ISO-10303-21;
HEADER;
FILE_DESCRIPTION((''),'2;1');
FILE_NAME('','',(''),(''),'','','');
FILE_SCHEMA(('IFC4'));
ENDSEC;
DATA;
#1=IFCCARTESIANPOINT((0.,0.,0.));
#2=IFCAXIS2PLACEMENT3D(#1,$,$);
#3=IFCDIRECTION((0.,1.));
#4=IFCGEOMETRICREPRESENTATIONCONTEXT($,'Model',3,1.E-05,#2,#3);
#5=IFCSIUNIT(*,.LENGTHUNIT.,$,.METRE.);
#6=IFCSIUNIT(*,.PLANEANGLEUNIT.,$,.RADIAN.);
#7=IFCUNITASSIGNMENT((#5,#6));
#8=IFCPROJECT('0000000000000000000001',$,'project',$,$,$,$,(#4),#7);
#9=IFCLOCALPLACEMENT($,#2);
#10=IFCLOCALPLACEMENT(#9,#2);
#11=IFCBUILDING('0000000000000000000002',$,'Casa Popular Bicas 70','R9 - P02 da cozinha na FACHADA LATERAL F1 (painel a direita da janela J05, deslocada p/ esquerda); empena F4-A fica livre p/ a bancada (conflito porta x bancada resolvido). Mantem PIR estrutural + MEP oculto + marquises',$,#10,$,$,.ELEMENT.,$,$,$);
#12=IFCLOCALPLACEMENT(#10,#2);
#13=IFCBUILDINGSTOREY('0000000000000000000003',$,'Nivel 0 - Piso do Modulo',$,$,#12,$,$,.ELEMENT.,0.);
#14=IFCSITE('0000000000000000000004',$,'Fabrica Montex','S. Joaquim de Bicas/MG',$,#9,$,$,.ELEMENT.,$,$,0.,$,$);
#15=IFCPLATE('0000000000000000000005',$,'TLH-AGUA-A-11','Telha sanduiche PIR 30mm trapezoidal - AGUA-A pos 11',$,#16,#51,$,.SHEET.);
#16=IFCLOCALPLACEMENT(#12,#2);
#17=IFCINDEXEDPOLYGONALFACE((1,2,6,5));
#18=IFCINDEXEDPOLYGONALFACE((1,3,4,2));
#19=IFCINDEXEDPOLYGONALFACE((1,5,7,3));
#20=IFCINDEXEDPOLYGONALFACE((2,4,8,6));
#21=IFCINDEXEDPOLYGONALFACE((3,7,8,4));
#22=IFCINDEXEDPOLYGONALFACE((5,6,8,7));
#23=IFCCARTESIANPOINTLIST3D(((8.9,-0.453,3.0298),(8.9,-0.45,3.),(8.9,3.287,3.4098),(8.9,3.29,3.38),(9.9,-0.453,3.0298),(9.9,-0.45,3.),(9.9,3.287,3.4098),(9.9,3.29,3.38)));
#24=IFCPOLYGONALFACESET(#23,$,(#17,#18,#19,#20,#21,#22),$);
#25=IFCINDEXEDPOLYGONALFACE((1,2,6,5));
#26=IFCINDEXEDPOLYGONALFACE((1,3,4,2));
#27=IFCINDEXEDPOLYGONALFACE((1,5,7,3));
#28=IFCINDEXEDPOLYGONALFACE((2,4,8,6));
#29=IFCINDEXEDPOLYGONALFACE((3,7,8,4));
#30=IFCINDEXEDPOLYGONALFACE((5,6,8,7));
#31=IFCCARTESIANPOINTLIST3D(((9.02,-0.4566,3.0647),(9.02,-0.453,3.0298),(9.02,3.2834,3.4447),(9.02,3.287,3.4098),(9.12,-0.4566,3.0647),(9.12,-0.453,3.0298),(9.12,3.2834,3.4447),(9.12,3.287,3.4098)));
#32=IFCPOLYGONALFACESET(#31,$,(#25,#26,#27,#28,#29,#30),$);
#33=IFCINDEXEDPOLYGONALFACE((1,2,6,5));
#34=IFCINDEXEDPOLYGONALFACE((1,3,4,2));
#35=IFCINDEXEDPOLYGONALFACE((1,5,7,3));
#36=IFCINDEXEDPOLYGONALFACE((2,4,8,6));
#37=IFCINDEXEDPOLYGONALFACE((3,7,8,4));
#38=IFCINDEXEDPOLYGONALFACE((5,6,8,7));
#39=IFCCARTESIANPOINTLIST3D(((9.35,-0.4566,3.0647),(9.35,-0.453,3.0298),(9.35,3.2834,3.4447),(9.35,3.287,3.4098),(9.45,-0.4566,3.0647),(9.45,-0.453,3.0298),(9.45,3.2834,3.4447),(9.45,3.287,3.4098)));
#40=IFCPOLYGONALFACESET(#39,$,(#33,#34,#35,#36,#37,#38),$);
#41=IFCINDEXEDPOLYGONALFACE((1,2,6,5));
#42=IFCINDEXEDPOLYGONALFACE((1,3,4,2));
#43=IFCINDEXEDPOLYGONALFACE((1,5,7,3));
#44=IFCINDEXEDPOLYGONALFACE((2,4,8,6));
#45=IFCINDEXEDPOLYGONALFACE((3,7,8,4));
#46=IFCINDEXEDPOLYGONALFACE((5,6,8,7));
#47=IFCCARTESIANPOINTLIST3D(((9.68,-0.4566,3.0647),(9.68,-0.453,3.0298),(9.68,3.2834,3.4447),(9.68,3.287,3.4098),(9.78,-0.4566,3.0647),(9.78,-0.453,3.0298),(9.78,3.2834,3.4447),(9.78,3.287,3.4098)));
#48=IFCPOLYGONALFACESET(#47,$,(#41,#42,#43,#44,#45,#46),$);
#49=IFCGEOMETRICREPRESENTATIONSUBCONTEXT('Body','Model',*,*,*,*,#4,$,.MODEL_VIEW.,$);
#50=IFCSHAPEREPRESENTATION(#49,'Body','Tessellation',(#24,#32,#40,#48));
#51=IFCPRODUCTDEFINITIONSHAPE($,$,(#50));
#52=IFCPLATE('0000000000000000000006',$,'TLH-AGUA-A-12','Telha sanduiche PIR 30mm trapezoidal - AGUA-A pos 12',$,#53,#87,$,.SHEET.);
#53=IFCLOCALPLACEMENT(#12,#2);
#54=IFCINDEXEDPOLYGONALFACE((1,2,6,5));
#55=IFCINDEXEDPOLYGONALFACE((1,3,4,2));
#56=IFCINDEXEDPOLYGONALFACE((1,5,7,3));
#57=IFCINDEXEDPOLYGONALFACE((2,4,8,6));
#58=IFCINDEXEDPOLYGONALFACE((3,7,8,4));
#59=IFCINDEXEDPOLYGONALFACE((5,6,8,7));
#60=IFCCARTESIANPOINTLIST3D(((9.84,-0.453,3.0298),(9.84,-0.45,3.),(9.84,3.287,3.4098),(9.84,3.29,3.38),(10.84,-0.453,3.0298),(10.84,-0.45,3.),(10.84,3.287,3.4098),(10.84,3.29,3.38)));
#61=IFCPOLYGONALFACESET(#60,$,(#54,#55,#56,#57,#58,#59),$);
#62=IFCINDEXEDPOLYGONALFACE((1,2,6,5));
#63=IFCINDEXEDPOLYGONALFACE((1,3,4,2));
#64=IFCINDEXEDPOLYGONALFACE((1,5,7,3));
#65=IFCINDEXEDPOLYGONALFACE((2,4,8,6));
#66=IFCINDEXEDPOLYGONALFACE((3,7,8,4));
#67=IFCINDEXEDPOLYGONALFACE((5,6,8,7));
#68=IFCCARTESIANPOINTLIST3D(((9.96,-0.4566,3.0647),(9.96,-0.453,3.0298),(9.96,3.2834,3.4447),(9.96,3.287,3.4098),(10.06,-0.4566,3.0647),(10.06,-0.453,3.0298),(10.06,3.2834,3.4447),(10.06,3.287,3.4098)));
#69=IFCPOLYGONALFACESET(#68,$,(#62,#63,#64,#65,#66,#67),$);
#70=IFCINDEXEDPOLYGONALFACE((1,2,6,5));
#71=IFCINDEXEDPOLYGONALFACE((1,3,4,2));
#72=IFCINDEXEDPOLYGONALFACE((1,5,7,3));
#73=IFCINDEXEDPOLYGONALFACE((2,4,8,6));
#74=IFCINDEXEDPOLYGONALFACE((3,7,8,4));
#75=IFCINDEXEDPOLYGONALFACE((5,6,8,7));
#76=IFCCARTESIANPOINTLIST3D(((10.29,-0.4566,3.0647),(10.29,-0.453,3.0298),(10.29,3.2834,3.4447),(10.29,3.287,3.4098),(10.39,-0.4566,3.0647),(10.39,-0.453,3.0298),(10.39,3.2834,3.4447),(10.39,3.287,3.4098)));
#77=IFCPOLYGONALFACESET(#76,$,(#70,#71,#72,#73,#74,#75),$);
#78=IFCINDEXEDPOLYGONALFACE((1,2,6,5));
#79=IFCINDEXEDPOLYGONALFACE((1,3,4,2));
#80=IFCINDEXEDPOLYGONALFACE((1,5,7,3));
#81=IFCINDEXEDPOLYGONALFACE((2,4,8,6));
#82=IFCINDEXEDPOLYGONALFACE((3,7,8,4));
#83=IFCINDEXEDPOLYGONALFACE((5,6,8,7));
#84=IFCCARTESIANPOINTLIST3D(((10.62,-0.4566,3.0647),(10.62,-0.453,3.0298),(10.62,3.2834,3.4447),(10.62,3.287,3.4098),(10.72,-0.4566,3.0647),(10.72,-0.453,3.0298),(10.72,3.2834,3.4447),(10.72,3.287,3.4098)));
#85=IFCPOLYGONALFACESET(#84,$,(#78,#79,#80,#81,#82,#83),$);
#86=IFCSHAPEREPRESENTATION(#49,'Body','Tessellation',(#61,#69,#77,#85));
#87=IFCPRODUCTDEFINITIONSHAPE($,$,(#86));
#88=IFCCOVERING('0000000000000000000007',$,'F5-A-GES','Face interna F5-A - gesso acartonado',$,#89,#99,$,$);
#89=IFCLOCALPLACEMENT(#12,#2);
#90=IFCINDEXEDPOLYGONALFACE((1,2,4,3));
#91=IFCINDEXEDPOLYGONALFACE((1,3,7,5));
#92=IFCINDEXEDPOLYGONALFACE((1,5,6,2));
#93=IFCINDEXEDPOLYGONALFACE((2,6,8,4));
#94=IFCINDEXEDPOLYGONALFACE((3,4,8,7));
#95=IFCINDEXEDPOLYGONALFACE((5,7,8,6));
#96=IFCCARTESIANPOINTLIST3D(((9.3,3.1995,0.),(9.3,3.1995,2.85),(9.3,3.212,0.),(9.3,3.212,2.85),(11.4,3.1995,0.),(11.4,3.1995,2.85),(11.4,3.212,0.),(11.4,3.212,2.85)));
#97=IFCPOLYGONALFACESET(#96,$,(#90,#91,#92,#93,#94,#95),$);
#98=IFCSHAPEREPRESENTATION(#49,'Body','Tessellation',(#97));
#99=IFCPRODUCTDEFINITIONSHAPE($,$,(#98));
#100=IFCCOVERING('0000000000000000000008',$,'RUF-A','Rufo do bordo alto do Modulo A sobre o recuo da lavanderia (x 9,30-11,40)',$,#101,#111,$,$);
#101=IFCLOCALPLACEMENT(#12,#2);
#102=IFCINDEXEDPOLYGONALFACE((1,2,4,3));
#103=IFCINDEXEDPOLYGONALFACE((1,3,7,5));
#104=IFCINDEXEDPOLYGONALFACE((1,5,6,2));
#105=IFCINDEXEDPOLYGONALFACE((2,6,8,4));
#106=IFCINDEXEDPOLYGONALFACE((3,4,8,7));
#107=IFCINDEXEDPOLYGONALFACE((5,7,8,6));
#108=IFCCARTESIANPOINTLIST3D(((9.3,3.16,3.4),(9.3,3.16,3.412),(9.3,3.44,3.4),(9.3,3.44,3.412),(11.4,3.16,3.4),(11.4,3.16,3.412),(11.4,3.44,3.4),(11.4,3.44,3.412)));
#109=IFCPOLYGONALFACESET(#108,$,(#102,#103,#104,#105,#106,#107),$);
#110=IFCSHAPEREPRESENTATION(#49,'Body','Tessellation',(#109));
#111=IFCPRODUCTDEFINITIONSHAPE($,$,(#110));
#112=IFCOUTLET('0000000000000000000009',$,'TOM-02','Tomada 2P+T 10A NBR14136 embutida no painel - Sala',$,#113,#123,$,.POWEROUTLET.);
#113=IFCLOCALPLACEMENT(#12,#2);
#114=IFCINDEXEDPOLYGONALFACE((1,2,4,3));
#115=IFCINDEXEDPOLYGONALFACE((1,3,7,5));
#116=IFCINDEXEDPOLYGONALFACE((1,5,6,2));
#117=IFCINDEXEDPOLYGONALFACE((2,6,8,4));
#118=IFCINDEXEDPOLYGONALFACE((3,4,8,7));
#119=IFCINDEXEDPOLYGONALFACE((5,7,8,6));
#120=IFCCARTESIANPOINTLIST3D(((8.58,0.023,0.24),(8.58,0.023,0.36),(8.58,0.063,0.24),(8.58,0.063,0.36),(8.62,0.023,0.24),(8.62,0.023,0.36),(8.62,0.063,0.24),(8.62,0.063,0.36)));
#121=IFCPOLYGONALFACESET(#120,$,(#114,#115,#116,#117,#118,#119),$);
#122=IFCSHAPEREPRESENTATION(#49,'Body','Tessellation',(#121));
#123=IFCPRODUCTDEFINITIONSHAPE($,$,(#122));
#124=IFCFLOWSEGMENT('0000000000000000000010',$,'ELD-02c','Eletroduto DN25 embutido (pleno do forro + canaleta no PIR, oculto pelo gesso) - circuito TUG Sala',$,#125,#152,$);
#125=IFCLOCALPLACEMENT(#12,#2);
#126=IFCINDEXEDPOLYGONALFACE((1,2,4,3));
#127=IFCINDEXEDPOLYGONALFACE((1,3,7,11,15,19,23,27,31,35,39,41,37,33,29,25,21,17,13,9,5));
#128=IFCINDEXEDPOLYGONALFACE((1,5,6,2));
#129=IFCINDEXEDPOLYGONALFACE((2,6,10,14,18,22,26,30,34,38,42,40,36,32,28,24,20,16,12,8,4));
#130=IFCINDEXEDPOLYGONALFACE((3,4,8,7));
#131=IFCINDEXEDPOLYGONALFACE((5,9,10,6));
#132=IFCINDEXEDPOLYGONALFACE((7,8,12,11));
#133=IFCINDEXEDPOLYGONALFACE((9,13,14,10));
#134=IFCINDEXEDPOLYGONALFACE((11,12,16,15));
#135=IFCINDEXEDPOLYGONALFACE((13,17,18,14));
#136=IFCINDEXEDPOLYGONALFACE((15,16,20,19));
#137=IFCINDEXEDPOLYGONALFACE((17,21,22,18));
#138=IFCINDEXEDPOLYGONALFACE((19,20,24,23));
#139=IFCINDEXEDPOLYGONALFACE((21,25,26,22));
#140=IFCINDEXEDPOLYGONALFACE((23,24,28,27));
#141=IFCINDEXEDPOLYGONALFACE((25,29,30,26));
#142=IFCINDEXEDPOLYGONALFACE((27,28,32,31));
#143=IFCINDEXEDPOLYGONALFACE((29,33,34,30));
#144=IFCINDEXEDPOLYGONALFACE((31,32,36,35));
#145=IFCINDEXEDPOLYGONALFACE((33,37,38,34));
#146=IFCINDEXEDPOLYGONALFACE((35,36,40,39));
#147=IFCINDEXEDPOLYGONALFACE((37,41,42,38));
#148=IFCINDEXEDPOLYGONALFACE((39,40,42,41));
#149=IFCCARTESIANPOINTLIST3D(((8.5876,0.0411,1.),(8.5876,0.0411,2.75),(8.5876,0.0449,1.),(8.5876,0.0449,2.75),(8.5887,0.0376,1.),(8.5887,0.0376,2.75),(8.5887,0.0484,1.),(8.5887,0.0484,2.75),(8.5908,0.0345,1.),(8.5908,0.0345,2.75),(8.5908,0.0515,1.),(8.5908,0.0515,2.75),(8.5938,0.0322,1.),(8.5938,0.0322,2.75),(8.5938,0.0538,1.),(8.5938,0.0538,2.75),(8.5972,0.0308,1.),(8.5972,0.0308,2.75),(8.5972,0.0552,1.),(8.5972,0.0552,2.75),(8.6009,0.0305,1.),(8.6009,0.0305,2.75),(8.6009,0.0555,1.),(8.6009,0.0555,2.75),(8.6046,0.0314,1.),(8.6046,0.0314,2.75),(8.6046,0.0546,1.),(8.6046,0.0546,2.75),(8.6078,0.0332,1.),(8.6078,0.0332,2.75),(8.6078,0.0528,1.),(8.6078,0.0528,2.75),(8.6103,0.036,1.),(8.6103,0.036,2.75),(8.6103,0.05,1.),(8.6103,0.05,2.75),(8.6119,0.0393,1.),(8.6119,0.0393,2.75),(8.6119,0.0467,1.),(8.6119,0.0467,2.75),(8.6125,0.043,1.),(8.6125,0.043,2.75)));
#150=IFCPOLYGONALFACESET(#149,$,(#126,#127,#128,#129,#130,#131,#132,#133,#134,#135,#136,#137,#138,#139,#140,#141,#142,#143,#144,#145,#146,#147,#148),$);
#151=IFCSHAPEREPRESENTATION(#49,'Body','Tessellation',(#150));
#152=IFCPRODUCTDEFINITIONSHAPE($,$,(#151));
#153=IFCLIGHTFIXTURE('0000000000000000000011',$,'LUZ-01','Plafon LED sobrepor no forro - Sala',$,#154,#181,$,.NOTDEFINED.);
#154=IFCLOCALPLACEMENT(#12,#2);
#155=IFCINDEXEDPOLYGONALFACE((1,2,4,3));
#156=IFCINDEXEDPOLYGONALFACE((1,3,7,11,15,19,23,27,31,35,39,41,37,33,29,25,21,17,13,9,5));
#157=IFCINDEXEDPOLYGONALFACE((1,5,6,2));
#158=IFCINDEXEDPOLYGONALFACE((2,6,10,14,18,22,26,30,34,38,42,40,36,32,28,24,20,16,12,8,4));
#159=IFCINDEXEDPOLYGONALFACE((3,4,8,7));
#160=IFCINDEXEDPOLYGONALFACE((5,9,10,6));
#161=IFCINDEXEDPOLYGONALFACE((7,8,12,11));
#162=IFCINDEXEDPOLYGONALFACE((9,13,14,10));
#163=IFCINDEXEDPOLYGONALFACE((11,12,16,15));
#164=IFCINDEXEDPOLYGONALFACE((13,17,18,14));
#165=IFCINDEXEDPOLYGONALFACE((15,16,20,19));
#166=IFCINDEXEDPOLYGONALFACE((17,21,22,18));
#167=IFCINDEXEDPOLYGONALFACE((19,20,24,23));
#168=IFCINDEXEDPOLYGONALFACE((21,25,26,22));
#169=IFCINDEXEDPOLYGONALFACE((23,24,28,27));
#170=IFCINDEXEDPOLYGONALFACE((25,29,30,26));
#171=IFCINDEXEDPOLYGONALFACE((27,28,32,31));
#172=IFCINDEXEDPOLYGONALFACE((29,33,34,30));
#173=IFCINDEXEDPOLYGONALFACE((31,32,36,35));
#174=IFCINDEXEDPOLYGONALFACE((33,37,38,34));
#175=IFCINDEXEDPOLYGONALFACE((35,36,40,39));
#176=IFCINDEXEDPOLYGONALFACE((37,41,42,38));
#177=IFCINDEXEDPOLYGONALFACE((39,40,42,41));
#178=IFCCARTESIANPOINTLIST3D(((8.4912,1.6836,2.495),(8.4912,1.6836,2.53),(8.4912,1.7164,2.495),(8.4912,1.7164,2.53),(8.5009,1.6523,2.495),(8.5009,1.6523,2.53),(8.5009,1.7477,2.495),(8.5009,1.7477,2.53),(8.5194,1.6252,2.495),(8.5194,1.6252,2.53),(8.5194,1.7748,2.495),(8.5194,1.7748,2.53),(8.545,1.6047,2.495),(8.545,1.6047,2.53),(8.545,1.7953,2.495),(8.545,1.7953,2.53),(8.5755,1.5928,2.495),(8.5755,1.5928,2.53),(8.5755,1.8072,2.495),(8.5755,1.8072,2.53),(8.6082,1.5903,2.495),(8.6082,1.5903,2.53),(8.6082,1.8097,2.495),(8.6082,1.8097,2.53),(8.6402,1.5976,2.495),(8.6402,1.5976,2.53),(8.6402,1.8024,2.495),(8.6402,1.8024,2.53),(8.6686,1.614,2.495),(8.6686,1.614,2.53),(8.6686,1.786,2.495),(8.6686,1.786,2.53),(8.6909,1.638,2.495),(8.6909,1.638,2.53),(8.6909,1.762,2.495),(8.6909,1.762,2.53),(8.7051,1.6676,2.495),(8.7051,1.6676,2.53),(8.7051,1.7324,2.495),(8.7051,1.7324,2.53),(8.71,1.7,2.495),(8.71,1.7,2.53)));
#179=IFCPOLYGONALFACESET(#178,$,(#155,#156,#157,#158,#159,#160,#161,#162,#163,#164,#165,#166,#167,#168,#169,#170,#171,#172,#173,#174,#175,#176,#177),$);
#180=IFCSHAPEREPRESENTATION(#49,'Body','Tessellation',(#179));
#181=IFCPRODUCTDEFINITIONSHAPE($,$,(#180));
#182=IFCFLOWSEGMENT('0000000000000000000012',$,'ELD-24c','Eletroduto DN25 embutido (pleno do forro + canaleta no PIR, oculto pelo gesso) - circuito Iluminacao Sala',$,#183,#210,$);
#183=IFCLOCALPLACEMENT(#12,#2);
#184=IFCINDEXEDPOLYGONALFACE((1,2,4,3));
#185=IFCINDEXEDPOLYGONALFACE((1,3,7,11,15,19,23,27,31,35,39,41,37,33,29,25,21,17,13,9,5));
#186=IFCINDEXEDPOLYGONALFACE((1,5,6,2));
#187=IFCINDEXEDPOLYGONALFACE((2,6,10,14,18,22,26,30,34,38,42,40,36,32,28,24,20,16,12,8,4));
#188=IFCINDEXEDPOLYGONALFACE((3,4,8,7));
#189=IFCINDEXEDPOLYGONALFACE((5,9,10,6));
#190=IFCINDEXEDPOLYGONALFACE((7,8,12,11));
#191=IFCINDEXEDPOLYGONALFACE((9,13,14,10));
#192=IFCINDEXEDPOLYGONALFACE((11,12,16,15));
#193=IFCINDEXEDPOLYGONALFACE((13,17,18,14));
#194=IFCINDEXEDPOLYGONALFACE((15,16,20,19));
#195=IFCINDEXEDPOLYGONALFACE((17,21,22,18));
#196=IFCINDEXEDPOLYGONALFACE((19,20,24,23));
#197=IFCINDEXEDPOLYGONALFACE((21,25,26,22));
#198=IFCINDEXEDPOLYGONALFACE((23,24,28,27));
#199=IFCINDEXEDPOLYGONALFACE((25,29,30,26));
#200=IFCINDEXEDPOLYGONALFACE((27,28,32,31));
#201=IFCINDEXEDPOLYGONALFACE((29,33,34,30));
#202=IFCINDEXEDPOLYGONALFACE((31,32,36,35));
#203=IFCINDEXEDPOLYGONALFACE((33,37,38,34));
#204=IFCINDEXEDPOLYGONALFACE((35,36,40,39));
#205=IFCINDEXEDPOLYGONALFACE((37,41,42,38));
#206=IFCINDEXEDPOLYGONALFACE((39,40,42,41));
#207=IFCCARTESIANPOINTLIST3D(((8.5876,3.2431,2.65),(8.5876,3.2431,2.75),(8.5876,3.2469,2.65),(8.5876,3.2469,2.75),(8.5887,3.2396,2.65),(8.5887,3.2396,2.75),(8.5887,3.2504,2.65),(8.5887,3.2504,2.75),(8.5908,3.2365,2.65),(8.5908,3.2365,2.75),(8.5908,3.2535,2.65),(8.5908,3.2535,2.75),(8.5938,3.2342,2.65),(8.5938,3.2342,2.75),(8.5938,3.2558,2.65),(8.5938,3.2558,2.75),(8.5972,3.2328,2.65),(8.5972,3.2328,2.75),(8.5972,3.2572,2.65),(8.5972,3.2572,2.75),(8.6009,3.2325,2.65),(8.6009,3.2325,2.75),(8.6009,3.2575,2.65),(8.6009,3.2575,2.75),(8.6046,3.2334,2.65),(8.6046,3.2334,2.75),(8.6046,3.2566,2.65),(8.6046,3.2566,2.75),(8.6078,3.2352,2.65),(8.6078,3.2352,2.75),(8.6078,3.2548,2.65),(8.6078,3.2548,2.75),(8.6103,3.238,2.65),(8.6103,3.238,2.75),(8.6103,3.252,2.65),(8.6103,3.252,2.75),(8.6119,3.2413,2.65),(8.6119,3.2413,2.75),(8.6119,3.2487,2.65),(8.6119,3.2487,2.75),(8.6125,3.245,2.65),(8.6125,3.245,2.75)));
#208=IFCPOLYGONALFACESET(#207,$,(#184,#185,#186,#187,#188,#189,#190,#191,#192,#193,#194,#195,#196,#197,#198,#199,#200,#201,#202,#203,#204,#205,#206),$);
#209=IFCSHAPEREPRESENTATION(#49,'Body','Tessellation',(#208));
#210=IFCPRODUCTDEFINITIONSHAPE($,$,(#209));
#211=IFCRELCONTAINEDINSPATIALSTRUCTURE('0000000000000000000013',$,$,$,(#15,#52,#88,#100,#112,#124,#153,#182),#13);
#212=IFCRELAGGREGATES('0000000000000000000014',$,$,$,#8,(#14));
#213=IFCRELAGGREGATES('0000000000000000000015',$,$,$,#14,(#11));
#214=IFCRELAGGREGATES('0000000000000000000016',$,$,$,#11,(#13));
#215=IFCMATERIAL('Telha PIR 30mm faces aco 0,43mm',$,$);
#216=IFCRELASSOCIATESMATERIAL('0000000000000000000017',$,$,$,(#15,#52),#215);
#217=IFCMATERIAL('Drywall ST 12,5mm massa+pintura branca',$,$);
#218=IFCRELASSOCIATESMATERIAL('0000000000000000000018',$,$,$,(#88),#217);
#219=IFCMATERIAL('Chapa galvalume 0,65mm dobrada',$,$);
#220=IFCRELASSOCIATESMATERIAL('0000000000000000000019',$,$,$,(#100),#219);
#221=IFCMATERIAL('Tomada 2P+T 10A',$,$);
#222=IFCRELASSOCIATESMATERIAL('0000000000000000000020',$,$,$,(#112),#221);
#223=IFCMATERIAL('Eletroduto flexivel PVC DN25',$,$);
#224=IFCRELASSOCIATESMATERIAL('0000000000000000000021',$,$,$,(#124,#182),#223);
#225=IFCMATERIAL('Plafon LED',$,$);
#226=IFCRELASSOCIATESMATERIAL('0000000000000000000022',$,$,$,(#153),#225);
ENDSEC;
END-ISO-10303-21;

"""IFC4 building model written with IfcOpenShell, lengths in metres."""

from ifc_helpers import new_model, si_unit, direction, frame, frame_2d, origin, origin_2d, place, context, subcontext, project, spatial, rectangle, circle, extrude, material, element, save


model = new_model("IFC4")

# Units and contexts
model_context = context("Model", 3, precision=1e-05, world=origin(), true_north=direction((0.0, 1.0)))
body_context = subcontext(model_context, "Body", "Model", "MODEL_VIEW")
ifc_project = project(units=[si_unit("LENGTHUNIT", "METRE"), si_unit("PLANEANGLEUNIT", "RADIAN")], contexts=[model_context])

# Site, building, storey
site_placement = place(None, origin())
site = spatial("IfcSite", under=ifc_project, at=site_placement, Name="Fabrica Montex", Description="S. Joaquim de Bicas/MG", CompositionType="ELEMENT", RefElevation=0.0)
building_placement = place(site_placement, origin())
building = spatial("IfcBuilding", under=site, at=building_placement, Name="Casa Popular Bicas 70", Description="R9 - P02 da cozinha na FACHADA LATERAL F1 (painel a direita da janela J05, deslocada p/ esquerda); empena F4-A fica livre p/ a bancada (conflito porta x bancada resolvido). Mantem PIR estrutural + MEP oculto + marquises", CompositionType="ELEMENT")
storey_placement = place(building_placement, origin())
storey = spatial("IfcBuildingStorey", under=building, at=storey_placement, Name="Nivel 0 - Piso do Modulo", CompositionType="ELEMENT", Elevation=0.0)

# Plates
ifc_material_1 = material(Name="Telha PIR 30mm faces aco 0,43mm")
for number, where, z_axis, x_axis, name, description in (
    (1, (8.9, -0.45, 3.0), (0.0, -0.101084, 0.994878), (1.0, 0.0, 0.0), "TLH-AGUA-A-11", "Telha sanduiche PIR 30mm trapezoidal - AGUA-A pos 11"),
    (2, (9.84, -0.45, 3.0), (0.0, -0.101084, 0.994878), (1.0, 0.0, 0.0), "TLH-AGUA-A-12", "Telha sanduiche PIR 30mm trapezoidal - AGUA-A pos 12"),
):
    element("IfcPlate", number, at=place(storey_placement, frame(where, z_axis=z_axis, x_axis=x_axis)), inside=storey, material=ifc_material_1, Name=name, Description=description, PredefinedType="SHEET", context=body_context, shape_type="SweptSolid", body=[
        extrude(rectangle(XDim=1.0, YDim=3.7593, at=frame_2d((0.5, 1.8796))), origin(), (0.0, 0.0, 1.0), 0.03),
        extrude(rectangle(XDim=0.1, YDim=3.7593, at=frame_2d((0.17, 1.8796))), frame((0.0, 0.0, 0.03)), (0.0, 0.0, 1.0), 0.035),
        extrude(rectangle(XDim=0.1, YDim=3.7593, at=frame_2d((0.5, 1.8796))), frame((0.0, 0.0, 0.03)), (0.0, 0.0, 1.0), 0.035),
        extrude(rectangle(XDim=0.1, YDim=3.7593, at=frame_2d((0.83, 1.8796))), frame((0.0, 0.0, 0.03)), (0.0, 0.0, 1.0), 0.035),
    ])

# Coverings
ifc_material_2 = material(Name="Drywall ST 12,5mm massa+pintura branca")
covering_1_placement = place(storey_placement, frame((9.3, 3.2058, 0.0), x_axis=(1.0, 0.0, 0.0)))
element("IfcCovering", 3, at=covering_1_placement, inside=storey, material=ifc_material_2, Name="F5-A-GES", Description="Face interna F5-A - gesso acartonado", context=body_context, shape_type="SweptSolid", body=[
    extrude(rectangle(XDim=2.1, YDim=0.0125, at=frame_2d((1.05, 0.0))), origin(), (0.0, 0.0, 1.0), 2.85),
])
ifc_material_3 = material(Name="Chapa galvalume 0,65mm dobrada")
covering_2_placement = place(storey_placement, frame((9.3, 3.16, 3.4), x_axis=(1.0, 0.0, 0.0)))
element("IfcCovering", 4, at=covering_2_placement, inside=storey, material=ifc_material_3, Name="RUF-A", Description="Rufo do bordo alto do Modulo A sobre o recuo da lavanderia (x 9,30-11,40)", context=body_context, shape_type="SweptSolid", body=[
    extrude(rectangle(XDim=2.1, YDim=0.28, at=frame_2d((1.05, 0.14))), origin(), (0.0, 0.0, 1.0), 0.012),
])

# Outlet
ifc_material_4 = material(Name="Tomada 2P+T 10A")
outlet_placement = place(storey_placement, frame((8.58, 0.023, 0.24)))
element("IfcOutlet", 5, at=outlet_placement, inside=storey, material=ifc_material_4, Name="TOM-02", Description="Tomada 2P+T 10A NBR14136 embutida no painel - Sala", PredefinedType="POWEROUTLET", context=body_context, shape_type="SweptSolid", body=[
    extrude(rectangle(XDim=0.04, YDim=0.04, at=frame_2d((0.02, 0.02))), origin(), (0.0, 0.0, 1.0), 0.12),
])

# Flow segment
ifc_material_5 = material(Name="Eletroduto flexivel PVC DN25")
flow_segment_1_placement = place(storey_placement, frame((8.6, 0.043, 2.75), z_axis=(0.0, 0.0, -1.0), x_axis=(1.0, 0.0, 0.0)))
element("IfcFlowSegment", 6, at=flow_segment_1_placement, inside=storey, material=ifc_material_5, Name="ELD-02c", Description="Eletroduto DN25 embutido (pleno do forro + canaleta no PIR, oculto pelo gesso) - circuito TUG Sala", context=body_context, shape_type="SweptSolid", body=[
    extrude(circle(Radius=0.0125, at=origin_2d()), origin(), (0.0, 0.0, 1.0), 1.75),
])

# Light fixture
ifc_material_6 = material(Name="Plafon LED")
light_fixture_placement = place(storey_placement, frame((8.6, 1.7, 2.495)))
element("IfcLightFixture", 7, at=light_fixture_placement, inside=storey, material=ifc_material_6, Name="LUZ-01", Description="Plafon LED sobrepor no forro - Sala", PredefinedType="NOTDEFINED", context=body_context, shape_type="SweptSolid", body=[
    extrude(circle(Radius=0.11, at=origin_2d()), origin(), (0.0, 0.0, 1.0), 0.035),
])

# Flow segment
flow_segment_2_placement = place(storey_placement, frame((8.6, 3.245, 2.75), z_axis=(0.0, 0.0, -1.0), x_axis=(1.0, 0.0, 0.0)))
element("IfcFlowSegment", 8, at=flow_segment_2_placement, inside=storey, material=ifc_material_5, Name="ELD-24c", Description="Eletroduto DN25 embutido (pleno do forro + canaleta no PIR, oculto pelo gesso) - circuito Iluminacao Sala", context=body_context, shape_type="SweptSolid", body=[
    extrude(circle(Radius=0.0125, at=origin_2d()), origin(), (0.0, 0.0, 1.0), 0.1),
])

save(model, "model.ifc")
